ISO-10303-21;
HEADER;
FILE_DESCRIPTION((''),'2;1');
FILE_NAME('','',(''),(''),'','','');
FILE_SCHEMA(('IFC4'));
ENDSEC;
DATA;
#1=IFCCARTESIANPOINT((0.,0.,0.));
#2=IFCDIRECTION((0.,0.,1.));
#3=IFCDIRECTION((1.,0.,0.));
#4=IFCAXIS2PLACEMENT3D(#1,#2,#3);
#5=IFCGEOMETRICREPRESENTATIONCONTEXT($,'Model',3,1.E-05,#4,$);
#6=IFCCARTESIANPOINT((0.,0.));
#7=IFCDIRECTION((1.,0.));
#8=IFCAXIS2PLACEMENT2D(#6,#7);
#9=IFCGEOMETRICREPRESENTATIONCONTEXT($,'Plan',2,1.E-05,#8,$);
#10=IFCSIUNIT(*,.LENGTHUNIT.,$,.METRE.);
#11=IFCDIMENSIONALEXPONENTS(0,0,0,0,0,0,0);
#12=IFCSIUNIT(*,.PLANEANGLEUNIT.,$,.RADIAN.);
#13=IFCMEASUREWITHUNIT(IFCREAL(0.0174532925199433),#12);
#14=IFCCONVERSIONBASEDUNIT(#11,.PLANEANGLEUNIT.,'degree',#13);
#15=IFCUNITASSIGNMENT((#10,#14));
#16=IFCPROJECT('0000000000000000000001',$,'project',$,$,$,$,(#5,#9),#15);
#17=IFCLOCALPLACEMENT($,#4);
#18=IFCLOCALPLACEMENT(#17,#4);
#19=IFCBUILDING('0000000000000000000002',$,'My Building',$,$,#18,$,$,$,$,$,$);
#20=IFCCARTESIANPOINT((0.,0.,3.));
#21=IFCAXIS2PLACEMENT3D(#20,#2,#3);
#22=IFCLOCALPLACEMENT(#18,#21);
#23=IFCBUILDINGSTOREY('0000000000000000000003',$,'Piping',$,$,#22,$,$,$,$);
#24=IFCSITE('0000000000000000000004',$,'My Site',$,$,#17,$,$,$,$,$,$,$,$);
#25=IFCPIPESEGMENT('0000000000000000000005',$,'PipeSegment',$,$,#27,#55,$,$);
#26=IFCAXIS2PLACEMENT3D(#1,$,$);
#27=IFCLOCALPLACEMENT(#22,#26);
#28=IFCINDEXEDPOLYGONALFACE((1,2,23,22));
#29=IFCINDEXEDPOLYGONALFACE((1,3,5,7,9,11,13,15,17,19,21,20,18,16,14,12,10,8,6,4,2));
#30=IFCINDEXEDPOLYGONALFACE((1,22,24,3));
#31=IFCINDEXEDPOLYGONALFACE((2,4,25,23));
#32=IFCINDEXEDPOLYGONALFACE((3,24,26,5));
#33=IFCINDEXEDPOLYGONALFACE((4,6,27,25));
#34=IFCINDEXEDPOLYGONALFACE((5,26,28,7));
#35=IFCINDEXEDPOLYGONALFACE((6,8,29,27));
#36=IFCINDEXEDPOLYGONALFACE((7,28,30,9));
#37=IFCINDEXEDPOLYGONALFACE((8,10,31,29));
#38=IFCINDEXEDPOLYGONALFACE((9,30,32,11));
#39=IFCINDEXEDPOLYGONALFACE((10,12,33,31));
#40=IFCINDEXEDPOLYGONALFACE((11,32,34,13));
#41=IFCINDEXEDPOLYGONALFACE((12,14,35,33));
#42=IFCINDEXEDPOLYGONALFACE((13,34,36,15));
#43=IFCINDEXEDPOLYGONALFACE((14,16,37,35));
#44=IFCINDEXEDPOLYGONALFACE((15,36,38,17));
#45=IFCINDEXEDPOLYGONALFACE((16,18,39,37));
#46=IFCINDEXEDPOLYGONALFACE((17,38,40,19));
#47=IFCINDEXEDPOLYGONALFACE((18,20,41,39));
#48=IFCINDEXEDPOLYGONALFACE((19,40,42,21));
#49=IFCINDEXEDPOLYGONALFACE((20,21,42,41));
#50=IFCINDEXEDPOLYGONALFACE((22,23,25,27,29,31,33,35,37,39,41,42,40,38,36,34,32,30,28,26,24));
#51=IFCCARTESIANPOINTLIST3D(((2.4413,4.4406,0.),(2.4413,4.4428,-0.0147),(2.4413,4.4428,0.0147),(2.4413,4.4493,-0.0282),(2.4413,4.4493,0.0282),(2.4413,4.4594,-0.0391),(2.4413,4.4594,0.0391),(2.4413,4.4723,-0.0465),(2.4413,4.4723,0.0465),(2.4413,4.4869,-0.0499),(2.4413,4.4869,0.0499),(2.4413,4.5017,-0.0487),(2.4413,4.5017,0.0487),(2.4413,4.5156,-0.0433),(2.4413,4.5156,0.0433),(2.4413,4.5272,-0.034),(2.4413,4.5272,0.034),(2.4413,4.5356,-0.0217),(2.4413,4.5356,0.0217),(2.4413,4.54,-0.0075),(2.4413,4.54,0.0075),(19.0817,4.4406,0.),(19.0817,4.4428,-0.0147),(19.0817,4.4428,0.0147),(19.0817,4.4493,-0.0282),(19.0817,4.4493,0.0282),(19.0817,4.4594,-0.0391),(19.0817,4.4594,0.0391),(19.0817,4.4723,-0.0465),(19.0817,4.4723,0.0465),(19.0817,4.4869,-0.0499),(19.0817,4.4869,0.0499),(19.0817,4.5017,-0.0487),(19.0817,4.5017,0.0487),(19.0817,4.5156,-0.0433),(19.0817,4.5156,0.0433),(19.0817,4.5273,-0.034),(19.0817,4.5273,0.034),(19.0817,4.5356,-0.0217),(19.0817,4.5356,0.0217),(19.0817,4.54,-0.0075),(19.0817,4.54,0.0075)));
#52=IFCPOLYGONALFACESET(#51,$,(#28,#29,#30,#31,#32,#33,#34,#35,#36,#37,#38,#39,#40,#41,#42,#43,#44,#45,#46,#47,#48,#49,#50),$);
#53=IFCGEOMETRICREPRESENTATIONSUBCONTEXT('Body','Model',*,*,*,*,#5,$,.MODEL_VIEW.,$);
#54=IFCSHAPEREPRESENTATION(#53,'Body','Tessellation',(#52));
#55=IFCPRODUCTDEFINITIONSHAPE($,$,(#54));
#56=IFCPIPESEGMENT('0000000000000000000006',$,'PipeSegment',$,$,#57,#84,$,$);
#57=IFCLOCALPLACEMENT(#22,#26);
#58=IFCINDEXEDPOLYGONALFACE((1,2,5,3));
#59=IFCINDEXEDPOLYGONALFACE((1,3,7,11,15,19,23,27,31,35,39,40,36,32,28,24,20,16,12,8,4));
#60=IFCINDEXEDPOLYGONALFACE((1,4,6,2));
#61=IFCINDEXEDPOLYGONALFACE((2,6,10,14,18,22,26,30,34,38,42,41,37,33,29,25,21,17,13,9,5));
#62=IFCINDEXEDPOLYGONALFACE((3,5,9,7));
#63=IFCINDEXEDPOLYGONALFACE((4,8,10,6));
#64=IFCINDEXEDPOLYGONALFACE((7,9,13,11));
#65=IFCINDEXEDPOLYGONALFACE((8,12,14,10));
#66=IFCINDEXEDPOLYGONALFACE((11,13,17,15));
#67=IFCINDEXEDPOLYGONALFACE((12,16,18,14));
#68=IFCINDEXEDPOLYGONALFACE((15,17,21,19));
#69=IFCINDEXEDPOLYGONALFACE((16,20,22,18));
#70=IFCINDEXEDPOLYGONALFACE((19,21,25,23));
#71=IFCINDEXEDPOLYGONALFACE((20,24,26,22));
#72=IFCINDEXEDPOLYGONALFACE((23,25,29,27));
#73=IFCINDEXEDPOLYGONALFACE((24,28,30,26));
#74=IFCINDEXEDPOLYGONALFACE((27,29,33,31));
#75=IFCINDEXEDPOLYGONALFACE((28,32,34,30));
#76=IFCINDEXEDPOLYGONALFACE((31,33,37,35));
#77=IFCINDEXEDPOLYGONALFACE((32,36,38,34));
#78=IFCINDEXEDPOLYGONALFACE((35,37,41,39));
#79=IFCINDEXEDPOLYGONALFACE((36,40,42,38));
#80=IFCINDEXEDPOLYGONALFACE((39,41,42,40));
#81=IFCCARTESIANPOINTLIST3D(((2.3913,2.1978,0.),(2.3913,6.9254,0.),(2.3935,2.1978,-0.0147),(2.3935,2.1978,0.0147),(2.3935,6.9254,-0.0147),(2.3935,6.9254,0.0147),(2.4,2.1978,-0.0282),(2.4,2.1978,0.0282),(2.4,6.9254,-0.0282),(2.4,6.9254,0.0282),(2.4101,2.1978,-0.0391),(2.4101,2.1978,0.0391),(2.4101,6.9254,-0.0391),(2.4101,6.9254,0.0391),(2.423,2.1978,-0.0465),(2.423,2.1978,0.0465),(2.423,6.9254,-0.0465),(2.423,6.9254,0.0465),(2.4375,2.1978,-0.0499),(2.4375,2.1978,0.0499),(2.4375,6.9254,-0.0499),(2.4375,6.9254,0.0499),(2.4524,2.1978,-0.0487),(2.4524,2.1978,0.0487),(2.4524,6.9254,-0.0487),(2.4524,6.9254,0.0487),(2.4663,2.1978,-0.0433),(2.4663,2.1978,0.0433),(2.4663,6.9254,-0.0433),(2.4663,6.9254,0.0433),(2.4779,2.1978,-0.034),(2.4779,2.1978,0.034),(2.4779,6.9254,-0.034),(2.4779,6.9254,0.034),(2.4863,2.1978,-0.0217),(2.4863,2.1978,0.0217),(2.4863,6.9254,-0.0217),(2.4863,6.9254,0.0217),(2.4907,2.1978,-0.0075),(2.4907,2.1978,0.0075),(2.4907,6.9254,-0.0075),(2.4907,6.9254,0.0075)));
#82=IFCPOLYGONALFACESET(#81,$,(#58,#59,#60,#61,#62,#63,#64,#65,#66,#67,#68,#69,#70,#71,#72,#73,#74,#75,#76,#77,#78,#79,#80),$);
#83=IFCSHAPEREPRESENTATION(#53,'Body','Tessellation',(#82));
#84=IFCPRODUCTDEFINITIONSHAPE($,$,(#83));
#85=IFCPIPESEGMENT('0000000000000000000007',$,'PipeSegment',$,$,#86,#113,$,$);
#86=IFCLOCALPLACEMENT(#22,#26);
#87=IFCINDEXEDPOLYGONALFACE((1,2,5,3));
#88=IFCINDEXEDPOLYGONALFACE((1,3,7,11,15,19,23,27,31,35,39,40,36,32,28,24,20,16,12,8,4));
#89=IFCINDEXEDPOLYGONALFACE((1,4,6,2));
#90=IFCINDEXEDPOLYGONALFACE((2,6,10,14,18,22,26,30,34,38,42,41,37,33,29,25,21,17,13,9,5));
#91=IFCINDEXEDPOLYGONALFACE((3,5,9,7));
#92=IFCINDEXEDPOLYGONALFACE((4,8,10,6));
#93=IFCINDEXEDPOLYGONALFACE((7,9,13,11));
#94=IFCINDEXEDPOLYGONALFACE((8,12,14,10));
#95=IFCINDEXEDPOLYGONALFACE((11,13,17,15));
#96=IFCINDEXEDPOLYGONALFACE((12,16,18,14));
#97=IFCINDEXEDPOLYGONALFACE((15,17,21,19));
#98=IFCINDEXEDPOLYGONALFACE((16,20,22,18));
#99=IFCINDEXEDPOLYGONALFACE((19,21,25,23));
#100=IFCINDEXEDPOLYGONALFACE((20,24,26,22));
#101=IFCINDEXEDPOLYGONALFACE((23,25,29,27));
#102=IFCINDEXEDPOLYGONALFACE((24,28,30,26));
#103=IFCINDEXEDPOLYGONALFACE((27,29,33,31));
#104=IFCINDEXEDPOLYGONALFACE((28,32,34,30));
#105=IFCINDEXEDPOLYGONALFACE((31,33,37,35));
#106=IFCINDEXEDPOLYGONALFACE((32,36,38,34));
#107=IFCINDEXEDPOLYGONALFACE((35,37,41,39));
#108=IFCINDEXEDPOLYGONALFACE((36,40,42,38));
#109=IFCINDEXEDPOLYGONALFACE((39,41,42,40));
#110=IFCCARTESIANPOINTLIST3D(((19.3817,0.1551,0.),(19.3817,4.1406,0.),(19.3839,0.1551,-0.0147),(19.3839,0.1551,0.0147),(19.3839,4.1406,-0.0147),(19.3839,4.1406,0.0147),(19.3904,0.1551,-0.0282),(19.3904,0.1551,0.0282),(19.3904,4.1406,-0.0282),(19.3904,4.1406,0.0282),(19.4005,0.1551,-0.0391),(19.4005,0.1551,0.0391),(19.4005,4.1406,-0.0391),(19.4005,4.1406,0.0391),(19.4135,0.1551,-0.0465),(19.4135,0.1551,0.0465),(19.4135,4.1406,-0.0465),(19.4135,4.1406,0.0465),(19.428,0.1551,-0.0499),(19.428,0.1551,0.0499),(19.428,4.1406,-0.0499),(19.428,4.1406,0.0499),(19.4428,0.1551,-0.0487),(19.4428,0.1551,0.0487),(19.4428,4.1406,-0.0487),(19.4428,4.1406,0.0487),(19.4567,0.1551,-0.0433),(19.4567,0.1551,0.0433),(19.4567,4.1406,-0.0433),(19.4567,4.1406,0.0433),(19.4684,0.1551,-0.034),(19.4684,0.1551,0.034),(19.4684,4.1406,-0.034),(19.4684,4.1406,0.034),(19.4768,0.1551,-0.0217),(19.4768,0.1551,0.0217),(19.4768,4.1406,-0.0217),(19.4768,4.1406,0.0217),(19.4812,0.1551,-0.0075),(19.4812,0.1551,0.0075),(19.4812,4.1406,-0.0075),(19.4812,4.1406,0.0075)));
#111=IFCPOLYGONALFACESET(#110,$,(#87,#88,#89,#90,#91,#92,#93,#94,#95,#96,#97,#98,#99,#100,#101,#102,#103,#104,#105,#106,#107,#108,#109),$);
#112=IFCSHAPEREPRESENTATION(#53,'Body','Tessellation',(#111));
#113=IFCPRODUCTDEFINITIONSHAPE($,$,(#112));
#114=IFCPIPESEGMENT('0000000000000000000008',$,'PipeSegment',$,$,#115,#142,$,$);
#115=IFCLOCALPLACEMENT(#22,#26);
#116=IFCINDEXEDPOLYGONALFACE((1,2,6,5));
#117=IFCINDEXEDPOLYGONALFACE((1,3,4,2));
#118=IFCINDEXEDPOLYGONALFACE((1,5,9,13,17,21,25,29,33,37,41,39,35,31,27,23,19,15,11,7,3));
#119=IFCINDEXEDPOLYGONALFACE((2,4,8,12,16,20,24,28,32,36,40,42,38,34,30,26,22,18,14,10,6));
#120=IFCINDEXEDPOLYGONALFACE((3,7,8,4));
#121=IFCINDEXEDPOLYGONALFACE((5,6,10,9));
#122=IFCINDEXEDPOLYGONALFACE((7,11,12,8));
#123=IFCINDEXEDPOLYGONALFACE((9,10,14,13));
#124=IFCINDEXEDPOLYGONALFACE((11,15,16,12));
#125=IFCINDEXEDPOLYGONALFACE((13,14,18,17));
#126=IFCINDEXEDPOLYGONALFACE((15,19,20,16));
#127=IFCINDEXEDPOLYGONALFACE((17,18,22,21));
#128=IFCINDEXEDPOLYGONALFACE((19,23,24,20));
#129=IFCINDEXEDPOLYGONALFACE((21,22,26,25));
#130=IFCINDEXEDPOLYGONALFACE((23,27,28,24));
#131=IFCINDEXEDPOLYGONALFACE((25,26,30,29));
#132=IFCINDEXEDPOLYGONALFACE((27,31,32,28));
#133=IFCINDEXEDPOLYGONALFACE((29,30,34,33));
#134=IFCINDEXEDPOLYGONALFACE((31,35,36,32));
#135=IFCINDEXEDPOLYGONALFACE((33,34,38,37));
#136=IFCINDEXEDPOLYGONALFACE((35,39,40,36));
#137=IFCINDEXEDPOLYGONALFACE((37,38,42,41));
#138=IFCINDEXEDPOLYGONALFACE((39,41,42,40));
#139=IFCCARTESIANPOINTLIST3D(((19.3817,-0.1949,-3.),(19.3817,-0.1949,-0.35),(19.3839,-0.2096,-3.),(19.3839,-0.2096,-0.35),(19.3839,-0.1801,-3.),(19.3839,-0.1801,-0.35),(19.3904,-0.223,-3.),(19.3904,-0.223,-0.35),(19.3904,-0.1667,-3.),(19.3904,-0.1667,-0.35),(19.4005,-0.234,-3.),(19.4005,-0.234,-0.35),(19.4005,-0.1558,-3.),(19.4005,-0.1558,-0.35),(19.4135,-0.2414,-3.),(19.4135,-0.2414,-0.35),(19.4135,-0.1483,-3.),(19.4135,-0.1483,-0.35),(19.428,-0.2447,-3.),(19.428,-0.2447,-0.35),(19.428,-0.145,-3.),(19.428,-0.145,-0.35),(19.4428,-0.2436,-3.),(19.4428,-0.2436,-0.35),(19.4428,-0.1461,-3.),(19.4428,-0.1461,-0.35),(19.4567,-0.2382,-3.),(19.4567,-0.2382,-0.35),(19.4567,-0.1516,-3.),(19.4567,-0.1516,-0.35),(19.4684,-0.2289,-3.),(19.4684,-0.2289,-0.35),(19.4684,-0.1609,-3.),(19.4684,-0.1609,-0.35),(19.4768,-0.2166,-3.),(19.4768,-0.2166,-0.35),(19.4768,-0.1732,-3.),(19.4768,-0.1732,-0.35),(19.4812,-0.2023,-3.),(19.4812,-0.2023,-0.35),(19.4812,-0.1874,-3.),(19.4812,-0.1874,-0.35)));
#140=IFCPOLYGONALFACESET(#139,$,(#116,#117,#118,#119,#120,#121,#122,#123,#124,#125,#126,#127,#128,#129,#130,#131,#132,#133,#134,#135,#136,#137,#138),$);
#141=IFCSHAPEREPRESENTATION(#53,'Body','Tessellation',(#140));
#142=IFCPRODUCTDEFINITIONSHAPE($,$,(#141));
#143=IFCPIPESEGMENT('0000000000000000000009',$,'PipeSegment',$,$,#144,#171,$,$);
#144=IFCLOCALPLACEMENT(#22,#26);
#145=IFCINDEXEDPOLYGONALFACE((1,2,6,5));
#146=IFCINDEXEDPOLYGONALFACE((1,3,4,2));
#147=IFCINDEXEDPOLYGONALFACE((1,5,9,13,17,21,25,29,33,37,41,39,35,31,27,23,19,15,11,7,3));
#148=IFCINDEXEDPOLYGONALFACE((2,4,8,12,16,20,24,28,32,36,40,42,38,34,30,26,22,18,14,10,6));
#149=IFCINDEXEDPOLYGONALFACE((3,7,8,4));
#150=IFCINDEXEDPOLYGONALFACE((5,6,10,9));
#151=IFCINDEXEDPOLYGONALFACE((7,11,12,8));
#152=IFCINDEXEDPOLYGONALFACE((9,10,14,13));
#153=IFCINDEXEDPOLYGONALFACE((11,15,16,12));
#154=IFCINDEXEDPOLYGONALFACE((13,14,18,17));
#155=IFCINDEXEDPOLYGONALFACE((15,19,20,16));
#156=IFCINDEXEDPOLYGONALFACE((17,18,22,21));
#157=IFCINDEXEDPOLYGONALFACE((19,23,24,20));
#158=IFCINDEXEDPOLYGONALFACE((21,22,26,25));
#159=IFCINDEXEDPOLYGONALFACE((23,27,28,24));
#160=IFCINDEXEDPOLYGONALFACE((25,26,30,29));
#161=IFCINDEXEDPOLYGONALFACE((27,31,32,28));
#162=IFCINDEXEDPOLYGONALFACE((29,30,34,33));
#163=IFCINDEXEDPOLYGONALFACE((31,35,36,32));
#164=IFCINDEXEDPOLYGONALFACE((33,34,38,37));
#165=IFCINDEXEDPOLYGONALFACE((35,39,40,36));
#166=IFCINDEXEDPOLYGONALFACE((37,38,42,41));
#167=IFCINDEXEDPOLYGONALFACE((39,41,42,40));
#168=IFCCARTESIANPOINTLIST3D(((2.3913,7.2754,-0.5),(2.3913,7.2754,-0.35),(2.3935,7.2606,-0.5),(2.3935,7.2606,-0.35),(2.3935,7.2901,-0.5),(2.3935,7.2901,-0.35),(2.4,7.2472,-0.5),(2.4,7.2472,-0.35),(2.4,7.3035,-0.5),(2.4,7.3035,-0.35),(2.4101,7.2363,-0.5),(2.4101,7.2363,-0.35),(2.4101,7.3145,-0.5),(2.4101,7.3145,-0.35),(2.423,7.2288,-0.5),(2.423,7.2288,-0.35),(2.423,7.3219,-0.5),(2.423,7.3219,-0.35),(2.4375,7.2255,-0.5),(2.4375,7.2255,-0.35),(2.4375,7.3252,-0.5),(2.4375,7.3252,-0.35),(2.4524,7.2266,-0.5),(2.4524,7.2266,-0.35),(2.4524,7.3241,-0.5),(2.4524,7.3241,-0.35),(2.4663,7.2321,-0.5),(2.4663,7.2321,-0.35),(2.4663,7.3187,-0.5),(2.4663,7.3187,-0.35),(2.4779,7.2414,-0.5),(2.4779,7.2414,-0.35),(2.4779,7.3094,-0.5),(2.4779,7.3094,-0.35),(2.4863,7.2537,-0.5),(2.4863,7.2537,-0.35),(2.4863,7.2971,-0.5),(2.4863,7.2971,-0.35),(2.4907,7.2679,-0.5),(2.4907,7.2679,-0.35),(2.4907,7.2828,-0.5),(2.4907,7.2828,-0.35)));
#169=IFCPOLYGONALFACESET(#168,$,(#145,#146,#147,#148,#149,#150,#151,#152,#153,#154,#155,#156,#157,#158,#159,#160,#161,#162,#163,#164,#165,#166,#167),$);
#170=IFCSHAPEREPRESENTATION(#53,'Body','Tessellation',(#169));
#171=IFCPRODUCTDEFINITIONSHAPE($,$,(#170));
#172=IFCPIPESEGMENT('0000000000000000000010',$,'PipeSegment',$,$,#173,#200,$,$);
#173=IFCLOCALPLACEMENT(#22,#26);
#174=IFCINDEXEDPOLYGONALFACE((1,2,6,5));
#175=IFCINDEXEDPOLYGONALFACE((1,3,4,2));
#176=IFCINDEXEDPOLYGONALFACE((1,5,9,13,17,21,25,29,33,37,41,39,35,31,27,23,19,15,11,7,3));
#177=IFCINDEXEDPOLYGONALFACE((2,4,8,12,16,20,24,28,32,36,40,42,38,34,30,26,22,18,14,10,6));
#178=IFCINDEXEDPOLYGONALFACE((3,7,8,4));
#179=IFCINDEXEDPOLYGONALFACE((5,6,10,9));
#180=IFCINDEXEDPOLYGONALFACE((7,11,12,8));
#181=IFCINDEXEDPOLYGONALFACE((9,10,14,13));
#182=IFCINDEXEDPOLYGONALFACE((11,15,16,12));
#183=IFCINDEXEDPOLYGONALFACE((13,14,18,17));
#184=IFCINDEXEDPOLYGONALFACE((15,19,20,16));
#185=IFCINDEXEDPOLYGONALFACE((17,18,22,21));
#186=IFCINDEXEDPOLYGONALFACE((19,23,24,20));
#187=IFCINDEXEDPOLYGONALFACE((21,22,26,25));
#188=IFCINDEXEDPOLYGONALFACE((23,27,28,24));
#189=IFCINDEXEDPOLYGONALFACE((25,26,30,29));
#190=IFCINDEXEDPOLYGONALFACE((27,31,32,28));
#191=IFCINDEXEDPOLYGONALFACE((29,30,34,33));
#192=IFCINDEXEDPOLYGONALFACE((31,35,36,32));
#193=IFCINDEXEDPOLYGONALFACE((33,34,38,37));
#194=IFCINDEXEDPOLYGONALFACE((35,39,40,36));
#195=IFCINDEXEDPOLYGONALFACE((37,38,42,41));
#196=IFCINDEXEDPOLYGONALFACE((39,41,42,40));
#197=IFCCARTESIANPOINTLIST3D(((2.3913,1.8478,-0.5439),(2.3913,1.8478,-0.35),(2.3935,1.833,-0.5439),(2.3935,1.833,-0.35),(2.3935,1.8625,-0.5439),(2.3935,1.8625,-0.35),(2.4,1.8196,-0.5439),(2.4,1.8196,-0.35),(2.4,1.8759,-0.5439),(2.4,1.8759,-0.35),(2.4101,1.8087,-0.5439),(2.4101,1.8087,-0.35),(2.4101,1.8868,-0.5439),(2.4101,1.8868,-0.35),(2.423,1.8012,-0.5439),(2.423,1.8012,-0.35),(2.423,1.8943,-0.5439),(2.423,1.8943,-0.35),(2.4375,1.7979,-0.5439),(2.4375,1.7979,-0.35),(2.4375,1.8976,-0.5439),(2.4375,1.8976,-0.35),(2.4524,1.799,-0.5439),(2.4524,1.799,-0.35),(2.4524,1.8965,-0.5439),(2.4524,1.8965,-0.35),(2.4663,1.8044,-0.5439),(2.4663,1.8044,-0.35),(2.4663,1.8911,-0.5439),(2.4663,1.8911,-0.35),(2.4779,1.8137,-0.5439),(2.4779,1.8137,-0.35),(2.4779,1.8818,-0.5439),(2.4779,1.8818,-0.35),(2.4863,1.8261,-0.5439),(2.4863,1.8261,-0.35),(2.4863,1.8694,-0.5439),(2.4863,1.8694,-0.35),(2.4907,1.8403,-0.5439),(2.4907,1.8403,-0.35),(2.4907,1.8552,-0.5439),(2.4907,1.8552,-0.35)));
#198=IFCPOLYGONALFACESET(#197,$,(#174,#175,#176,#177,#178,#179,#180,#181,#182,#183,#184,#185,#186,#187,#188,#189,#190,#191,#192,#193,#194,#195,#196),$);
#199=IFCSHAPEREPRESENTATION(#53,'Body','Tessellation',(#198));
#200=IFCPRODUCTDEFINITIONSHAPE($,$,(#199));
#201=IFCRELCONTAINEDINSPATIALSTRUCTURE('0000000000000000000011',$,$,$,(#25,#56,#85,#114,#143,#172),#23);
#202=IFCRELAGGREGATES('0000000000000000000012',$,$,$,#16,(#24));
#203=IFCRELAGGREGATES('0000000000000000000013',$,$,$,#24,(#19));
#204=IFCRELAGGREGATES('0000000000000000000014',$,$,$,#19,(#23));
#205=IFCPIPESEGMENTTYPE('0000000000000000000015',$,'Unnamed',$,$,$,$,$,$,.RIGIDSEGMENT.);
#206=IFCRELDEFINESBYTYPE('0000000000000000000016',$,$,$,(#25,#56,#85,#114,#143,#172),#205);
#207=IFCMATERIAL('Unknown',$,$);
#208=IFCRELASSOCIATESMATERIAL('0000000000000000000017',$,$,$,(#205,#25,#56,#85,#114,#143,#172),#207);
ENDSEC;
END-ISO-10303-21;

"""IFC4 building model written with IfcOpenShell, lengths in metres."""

from ifc_helpers import new_model, entity, si_unit, converted_unit, frame, origin_with_axes, origin_2d_with_axis, place, context, subcontext, project, spatial, circle, extrude, material, material_profile, profile_set, profile_usage, type_object, element, save


model = new_model("IFC4")

# Units and contexts
model_context = context("Model", 3, precision=1e-05, world=origin_with_axes())
plan_context = context("Plan", 2, precision=1e-05, world=origin_2d_with_axis())
body_context = subcontext(model_context, "Body", "Model", "MODEL_VIEW")
ifc_project = project(units=[si_unit("LENGTHUNIT", "METRE"), converted_unit("PLANEANGLEUNIT", "degree", entity("IfcReal", 0.0174532925199433), si_unit("PLANEANGLEUNIT", "RADIAN"), dimensions=[0, 0, 0, 0, 0, 0, 0])], contexts=[model_context, plan_context])

# Site, building, storey
site_placement = place(None, origin_with_axes())
site = spatial("IfcSite", under=ifc_project, at=site_placement, Name="My Site")
building_placement = place(site_placement, origin_with_axes())
building = spatial("IfcBuilding", under=site, at=building_placement, Name="My Building")
storey_placement = place(building_placement, frame((0.0, 0.0, 3.0), z_axis=(0.0, 0.0, 1.0), x_axis=(1.0, 0.0, 0.0)))
storey = spatial("IfcBuildingStorey", under=building, at=storey_placement, Name="Piping")

# Pipe segments
ifc_material = material(Name="Unknown")
ifc_material_profile = material_profile(ifc_material, circle(Radius=0.05))
ifc_profile_set = profile_set([ifc_material_profile])
ifc_profile_usage_1 = profile_usage(ifc_profile_set, cardinal=5)
pipe_segment_type = type_object("IfcPipeSegmentType", Name="Unnamed", PredefinedType="RIGIDSEGMENT", material=ifc_profile_set)
pipe_segment_1_placement = place(storey_placement, frame((19.0817, 4.4906, 0.0), z_axis=(-1.0, 0.0, 0.0), x_axis=(0.0, -1.0, 0.0)))
element("IfcPipeSegment", 1, at=pipe_segment_1_placement, inside=storey, type_object=pipe_segment_type, material=ifc_profile_usage_1, Name="PipeSegment", context=body_context, shape_type="SweptSolid", body=[
    extrude(circle(Radius=0.05), origin_with_axes(), (0.0, 0.0, 1.0), 16.6404),
])
ifc_profile_usage_2 = profile_usage(ifc_profile_set, cardinal=5)
pipe_segment_2_placement = place(storey_placement, frame((2.4413, 2.1978, 0.0), z_axis=(0.0, 1.0, 0.0), x_axis=(-1.0, 0.0, 0.0)))
element("IfcPipeSegment", 2, at=pipe_segment_2_placement, inside=storey, type_object=pipe_segment_type, material=ifc_profile_usage_2, Name="PipeSegment", context=body_context, shape_type="SweptSolid", body=[
    extrude(circle(Radius=0.05), origin_with_axes(), (0.0, 0.0, 1.0), 4.7276),
])
ifc_profile_usage_3 = profile_usage(ifc_profile_set, cardinal=5)
pipe_segment_3_placement = place(storey_placement, frame((19.4317, 0.1551, 0.0), z_axis=(0.0, 1.0, 0.0), x_axis=(-1.0, 0.0, 0.0)))
element("IfcPipeSegment", 3, at=pipe_segment_3_placement, inside=storey, type_object=pipe_segment_type, material=ifc_profile_usage_3, Name="PipeSegment", context=body_context, shape_type="SweptSolid", body=[
    extrude(circle(Radius=0.05), origin_with_axes(), (0.0, 0.0, 1.0), 3.9855),
])
ifc_profile_usage_4 = profile_usage(ifc_profile_set, cardinal=5)
pipe_segment_4_placement = place(storey_placement, frame((19.4317, -0.1949, -0.35), z_axis=(0.0, 0.0, -1.0), x_axis=(-1.0, 0.0, 0.0)))
element("IfcPipeSegment", 4, at=pipe_segment_4_placement, inside=storey, type_object=pipe_segment_type, material=ifc_profile_usage_4, Name="PipeSegment", context=body_context, shape_type="SweptSolid", body=[
    extrude(circle(Radius=0.05), origin_with_axes(), (0.0, 0.0, 1.0), 2.65),
])
ifc_profile_usage_5 = profile_usage(ifc_profile_set, cardinal=5)
pipe_segment_5_placement = place(storey_placement, frame((2.4413, 7.2754, -0.35), z_axis=(0.0, 0.0, -1.0), x_axis=(-1.0, 0.0, 0.0)))
element("IfcPipeSegment", 5, at=pipe_segment_5_placement, inside=storey, type_object=pipe_segment_type, material=ifc_profile_usage_5, Name="PipeSegment", context=body_context, shape_type="SweptSolid", body=[
    extrude(circle(Radius=0.05), origin_with_axes(), (0.0, 0.0, 1.0), 0.15),
])
ifc_profile_usage_6 = profile_usage(ifc_profile_set, cardinal=5)
pipe_segment_6_placement = place(storey_placement, frame((2.4413, 1.8478, -0.35), z_axis=(0.0, 0.0, -1.0), x_axis=(-1.0, 0.0, 0.0)))
element("IfcPipeSegment", 6, at=pipe_segment_6_placement, inside=storey, type_object=pipe_segment_type, material=ifc_profile_usage_6, Name="PipeSegment", context=body_context, shape_type="SweptSolid", body=[
    extrude(circle(Radius=0.05), origin_with_axes(), (0.0, 0.0, 1.0), 0.1939),
])

save(model, "model.ifc")
